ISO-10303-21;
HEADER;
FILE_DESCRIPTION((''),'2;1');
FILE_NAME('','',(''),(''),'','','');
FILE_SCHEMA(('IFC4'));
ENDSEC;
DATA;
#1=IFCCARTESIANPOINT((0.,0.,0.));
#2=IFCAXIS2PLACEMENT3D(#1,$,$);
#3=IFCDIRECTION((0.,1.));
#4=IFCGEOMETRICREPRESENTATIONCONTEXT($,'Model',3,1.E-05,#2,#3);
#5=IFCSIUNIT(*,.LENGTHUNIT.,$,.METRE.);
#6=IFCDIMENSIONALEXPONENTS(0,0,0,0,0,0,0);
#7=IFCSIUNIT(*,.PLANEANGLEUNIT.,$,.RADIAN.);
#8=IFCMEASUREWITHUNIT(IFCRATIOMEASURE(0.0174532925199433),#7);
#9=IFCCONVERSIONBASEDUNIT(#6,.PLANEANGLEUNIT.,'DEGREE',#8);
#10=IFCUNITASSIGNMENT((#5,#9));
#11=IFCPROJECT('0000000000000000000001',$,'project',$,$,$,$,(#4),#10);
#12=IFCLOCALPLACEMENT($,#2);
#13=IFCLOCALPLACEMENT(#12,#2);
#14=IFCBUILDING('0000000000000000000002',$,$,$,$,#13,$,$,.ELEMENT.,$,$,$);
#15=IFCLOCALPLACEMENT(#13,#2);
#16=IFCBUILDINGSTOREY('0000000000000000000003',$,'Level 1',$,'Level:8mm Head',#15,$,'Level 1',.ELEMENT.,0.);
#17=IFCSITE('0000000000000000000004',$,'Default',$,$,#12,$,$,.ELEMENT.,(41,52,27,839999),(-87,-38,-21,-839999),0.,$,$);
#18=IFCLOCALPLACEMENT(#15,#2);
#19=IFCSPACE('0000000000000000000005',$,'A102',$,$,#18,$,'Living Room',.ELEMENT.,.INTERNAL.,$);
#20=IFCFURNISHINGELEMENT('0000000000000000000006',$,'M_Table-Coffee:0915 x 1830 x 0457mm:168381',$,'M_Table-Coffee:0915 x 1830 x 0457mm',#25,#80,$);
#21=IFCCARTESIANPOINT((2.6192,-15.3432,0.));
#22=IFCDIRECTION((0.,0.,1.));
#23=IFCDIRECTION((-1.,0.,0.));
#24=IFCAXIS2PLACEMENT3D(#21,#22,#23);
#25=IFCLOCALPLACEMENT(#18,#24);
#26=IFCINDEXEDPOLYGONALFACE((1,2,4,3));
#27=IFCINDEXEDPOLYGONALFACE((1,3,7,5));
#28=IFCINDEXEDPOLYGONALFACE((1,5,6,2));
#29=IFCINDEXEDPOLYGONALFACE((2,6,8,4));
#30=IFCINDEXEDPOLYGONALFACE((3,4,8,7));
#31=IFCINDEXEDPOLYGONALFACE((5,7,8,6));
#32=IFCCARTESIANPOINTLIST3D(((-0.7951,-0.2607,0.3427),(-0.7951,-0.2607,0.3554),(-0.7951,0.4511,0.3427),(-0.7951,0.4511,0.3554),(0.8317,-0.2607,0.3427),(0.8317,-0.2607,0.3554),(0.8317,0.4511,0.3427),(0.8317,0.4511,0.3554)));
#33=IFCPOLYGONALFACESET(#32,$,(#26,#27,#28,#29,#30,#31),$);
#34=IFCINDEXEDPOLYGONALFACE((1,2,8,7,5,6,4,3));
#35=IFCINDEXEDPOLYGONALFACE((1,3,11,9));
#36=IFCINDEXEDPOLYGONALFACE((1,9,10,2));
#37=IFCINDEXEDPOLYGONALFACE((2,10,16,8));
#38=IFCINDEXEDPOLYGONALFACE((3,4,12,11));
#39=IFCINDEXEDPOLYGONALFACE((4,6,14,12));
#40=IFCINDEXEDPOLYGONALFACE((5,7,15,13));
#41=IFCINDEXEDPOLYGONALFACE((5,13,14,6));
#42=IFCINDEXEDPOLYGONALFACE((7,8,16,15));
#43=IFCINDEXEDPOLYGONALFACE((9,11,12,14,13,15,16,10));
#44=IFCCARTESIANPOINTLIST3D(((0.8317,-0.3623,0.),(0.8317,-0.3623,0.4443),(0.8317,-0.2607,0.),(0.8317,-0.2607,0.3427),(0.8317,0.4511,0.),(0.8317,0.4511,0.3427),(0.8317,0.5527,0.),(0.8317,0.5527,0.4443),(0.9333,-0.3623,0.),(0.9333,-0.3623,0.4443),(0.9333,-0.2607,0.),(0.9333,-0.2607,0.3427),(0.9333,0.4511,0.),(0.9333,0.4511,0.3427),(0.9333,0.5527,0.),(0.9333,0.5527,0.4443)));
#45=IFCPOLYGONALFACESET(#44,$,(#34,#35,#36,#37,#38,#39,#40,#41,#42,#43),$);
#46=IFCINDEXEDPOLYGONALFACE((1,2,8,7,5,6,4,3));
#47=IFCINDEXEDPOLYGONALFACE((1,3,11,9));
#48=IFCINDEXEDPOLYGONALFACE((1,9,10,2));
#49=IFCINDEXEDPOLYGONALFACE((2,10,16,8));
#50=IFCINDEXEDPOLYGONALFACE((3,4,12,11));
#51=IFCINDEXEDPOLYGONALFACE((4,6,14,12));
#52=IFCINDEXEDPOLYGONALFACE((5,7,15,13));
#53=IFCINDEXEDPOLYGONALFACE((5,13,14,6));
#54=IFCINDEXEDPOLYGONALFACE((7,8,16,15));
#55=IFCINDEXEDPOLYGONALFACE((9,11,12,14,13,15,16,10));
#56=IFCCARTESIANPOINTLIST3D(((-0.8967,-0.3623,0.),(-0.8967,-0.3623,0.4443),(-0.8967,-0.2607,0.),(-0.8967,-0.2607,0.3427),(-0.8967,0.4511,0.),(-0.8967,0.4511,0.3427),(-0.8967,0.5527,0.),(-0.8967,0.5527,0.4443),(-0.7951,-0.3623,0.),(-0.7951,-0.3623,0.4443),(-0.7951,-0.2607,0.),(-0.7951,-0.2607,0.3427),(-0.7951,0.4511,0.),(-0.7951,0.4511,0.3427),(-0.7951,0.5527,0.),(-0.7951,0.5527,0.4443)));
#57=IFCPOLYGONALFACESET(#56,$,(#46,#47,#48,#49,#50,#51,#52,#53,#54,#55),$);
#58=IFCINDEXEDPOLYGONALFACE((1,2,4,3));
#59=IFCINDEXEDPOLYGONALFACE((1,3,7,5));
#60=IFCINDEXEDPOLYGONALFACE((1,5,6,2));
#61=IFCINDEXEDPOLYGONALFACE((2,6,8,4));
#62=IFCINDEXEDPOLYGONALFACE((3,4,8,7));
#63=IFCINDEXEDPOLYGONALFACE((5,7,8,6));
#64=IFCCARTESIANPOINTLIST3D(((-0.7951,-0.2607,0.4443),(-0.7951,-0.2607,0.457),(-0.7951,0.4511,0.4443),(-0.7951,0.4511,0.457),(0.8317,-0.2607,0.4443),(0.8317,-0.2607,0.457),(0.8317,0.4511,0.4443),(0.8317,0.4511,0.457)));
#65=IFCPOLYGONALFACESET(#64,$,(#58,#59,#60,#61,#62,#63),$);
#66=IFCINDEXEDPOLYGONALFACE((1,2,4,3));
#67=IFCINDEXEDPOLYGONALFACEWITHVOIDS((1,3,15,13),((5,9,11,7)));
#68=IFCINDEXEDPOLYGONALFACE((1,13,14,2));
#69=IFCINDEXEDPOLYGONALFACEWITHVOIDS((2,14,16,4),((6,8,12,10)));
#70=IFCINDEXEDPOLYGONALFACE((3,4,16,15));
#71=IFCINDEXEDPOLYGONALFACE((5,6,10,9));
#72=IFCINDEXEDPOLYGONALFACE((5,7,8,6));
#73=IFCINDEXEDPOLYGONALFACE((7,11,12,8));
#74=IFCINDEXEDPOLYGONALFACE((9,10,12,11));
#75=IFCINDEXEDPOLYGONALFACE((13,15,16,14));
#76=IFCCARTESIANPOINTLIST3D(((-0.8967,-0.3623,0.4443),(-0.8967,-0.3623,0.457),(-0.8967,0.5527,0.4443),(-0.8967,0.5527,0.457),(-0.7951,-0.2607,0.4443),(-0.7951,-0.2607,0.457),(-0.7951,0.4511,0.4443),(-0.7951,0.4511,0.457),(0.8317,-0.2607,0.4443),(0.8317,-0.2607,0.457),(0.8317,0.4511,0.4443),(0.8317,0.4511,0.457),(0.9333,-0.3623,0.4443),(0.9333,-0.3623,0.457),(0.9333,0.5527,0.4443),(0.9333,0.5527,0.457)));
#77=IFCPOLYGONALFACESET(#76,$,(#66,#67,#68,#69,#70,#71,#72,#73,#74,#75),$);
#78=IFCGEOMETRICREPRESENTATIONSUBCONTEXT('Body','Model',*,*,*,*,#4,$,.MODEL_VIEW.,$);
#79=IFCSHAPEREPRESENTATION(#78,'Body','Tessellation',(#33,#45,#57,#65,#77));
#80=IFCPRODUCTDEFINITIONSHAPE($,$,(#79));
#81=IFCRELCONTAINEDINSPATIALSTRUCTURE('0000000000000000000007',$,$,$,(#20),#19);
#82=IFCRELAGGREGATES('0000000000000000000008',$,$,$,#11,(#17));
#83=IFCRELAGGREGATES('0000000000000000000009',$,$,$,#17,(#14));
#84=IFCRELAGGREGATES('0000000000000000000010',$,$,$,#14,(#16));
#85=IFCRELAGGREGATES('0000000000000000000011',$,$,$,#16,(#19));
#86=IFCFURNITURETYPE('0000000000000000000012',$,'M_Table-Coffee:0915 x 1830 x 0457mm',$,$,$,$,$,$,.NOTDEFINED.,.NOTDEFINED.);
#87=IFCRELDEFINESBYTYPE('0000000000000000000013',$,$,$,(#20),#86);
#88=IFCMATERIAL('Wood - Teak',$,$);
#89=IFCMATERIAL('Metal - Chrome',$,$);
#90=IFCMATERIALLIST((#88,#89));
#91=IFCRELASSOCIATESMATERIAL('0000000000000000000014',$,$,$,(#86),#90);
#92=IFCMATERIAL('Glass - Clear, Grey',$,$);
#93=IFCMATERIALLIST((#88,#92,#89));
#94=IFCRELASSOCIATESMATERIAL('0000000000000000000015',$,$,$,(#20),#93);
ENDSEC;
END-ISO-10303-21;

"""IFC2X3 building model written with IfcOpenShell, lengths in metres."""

from ifc_helpers import new_model, entity, si_unit, converted_unit, direction, frame, origin, origin_2d_with_axis, place, context, subcontext, project, spatial, polyline, rectangle, outline, extrude, source, transform, mapped, material, material_list, type_object, type_shapes, element, save


model = new_model("IFC2X3")

# Units and contexts
model_context = context("Model", 3, precision=1e-05, world=origin(), true_north=direction((0.0, 1.0)))
body_context = subcontext(model_context, "Body", "Model", "MODEL_VIEW")
ifc_project = project(units=[si_unit("LENGTHUNIT", "METRE"), converted_unit("PLANEANGLEUNIT", "DEGREE", entity("IfcRatioMeasure", 0.0174532925199433), si_unit("PLANEANGLEUNIT", "RADIAN"), dimensions=[0, 0, 0, 0, 0, 0, 0])], contexts=[model_context])

# Site, building, storey
site_placement = place(None, origin())
site = spatial("IfcSite", under=ifc_project, at=site_placement, Name="Default", CompositionType="ELEMENT", RefLatitude=(41, 52, 27, 839999), RefLongitude=(-87, -38, -21, -839999), RefElevation=0.0)
building_placement = place(site_placement, origin())
building = spatial("IfcBuilding", under=site, at=building_placement, CompositionType="ELEMENT")
storey_placement = place(building_placement, origin())
storey = spatial("IfcBuildingStorey", under=building, at=storey_placement, Name="Level 1", ObjectType="Level:8mm Head", LongName="Level 1", CompositionType="ELEMENT", Elevation=0.0)

# Shared definitions
space_1_placement = place(storey_placement, origin())
space_1 = spatial("IfcSpace", under=storey, at=space_1_placement, Name="A102", LongName="Living Room", CompositionType="ELEMENT", InteriorOrExteriorSpace="INTERNAL")

# Furnishing element
ifc_material_1 = material(Name="Wood - Teak")
ifc_material_2 = material(Name="Glass - Clear, Grey")
ifc_material_3 = material(Name="Metal - Chrome")
ifc_material_list_1 = material_list([ifc_material_1, ifc_material_2, ifc_material_3])
ifc_material_list_2 = material_list([ifc_material_1, ifc_material_3])
furniture_type_1 = type_object("IfcFurnitureType", Name="M_Table-Coffee:0915 x 1830 x 0457mm", material=ifc_material_list_2)
shared_shape_1 = source(origin(), body_context, "Body", "SweptSolid", [
    extrude(rectangle(XDim=1.6268, YDim=0.7118, at=origin_2d_with_axis()), frame((0.0183, 0.0952, 0.3427), z_axis=(0.0, 0.0, 1.0), x_axis=(-1.0, 0.0, 0.0)), (0.0, 0.0, 1.0), 0.0127),
    extrude(outline(polyline([(-0.1967, -0.4575), (0.2475, -0.4575), (0.2475, 0.4575), (-0.1967, 0.4575), (-0.1967, 0.3559), (0.146, 0.3559), (0.146, -0.3559), (-0.1967, -0.3559), (-0.1967, -0.4575)])), frame((0.8317, 0.0952, 0.1967), z_axis=(1.0, 0.0, 0.0), x_axis=(0.0, 0.0, 1.0)), (0.0, 0.0, 1.0), 0.1016),
    extrude(outline(polyline([(-0.4575, -0.2476), (0.4575, -0.2476), (0.4575, 0.1968), (0.3559, 0.1968), (0.3559, -0.1459), (-0.3559, -0.1459), (-0.3559, 0.1968), (-0.4575, 0.1968), (-0.4575, -0.2476)])), frame((-0.8967, 0.0952, 0.1968), z_axis=(1.0, 0.0, 0.0), x_axis=(0.0, -1.0, 0.0)), (0.0, 0.0, 1.0), 0.1016),
    extrude(rectangle(XDim=1.6268, YDim=0.7118, at=origin_2d_with_axis()), frame((0.0183, 0.0952, 0.4443), z_axis=(0.0, 0.0, 1.0), x_axis=(-1.0, 0.0, 0.0)), (0.0, 0.0, 1.0), 0.0127),
    extrude(outline(polyline([(-0.915, -0.4575), (0.915, -0.4575), (0.915, 0.4575), (-0.915, 0.4575), (-0.915, -0.4575)]), holes=[polyline([(-0.8134, -0.3559), (-0.8134, 0.3559), (0.8134, 0.3559), (0.8134, -0.3559), (-0.8134, -0.3559)])]), frame((0.0183, 0.0952, 0.4443), z_axis=(0.0, 0.0, 1.0), x_axis=(-1.0, 0.0, 0.0)), (0.0, 0.0, 1.0), 0.0127),
])
type_shapes(furniture_type_1, [shared_shape_1])
furnishing_1_placement = place(space_1_placement, frame((2.6192, -15.3432, 0.0), z_axis=(0.0, 0.0, 1.0), x_axis=(-1.0, 0.0, 0.0)))
element("IfcFurnishingElement", 1, at=furnishing_1_placement, inside=space_1, type_object=furniture_type_1, material=ifc_material_list_1, Name="M_Table-Coffee:0915 x 1830 x 0457mm:168381", ObjectType="M_Table-Coffee:0915 x 1830 x 0457mm", context=body_context, shape_type="MappedRepresentation", body=[
    mapped(shared_shape_1, transform((0.0, 0.0, 0.0), scale=1.0)),
])

save(model, "model.ifc")
